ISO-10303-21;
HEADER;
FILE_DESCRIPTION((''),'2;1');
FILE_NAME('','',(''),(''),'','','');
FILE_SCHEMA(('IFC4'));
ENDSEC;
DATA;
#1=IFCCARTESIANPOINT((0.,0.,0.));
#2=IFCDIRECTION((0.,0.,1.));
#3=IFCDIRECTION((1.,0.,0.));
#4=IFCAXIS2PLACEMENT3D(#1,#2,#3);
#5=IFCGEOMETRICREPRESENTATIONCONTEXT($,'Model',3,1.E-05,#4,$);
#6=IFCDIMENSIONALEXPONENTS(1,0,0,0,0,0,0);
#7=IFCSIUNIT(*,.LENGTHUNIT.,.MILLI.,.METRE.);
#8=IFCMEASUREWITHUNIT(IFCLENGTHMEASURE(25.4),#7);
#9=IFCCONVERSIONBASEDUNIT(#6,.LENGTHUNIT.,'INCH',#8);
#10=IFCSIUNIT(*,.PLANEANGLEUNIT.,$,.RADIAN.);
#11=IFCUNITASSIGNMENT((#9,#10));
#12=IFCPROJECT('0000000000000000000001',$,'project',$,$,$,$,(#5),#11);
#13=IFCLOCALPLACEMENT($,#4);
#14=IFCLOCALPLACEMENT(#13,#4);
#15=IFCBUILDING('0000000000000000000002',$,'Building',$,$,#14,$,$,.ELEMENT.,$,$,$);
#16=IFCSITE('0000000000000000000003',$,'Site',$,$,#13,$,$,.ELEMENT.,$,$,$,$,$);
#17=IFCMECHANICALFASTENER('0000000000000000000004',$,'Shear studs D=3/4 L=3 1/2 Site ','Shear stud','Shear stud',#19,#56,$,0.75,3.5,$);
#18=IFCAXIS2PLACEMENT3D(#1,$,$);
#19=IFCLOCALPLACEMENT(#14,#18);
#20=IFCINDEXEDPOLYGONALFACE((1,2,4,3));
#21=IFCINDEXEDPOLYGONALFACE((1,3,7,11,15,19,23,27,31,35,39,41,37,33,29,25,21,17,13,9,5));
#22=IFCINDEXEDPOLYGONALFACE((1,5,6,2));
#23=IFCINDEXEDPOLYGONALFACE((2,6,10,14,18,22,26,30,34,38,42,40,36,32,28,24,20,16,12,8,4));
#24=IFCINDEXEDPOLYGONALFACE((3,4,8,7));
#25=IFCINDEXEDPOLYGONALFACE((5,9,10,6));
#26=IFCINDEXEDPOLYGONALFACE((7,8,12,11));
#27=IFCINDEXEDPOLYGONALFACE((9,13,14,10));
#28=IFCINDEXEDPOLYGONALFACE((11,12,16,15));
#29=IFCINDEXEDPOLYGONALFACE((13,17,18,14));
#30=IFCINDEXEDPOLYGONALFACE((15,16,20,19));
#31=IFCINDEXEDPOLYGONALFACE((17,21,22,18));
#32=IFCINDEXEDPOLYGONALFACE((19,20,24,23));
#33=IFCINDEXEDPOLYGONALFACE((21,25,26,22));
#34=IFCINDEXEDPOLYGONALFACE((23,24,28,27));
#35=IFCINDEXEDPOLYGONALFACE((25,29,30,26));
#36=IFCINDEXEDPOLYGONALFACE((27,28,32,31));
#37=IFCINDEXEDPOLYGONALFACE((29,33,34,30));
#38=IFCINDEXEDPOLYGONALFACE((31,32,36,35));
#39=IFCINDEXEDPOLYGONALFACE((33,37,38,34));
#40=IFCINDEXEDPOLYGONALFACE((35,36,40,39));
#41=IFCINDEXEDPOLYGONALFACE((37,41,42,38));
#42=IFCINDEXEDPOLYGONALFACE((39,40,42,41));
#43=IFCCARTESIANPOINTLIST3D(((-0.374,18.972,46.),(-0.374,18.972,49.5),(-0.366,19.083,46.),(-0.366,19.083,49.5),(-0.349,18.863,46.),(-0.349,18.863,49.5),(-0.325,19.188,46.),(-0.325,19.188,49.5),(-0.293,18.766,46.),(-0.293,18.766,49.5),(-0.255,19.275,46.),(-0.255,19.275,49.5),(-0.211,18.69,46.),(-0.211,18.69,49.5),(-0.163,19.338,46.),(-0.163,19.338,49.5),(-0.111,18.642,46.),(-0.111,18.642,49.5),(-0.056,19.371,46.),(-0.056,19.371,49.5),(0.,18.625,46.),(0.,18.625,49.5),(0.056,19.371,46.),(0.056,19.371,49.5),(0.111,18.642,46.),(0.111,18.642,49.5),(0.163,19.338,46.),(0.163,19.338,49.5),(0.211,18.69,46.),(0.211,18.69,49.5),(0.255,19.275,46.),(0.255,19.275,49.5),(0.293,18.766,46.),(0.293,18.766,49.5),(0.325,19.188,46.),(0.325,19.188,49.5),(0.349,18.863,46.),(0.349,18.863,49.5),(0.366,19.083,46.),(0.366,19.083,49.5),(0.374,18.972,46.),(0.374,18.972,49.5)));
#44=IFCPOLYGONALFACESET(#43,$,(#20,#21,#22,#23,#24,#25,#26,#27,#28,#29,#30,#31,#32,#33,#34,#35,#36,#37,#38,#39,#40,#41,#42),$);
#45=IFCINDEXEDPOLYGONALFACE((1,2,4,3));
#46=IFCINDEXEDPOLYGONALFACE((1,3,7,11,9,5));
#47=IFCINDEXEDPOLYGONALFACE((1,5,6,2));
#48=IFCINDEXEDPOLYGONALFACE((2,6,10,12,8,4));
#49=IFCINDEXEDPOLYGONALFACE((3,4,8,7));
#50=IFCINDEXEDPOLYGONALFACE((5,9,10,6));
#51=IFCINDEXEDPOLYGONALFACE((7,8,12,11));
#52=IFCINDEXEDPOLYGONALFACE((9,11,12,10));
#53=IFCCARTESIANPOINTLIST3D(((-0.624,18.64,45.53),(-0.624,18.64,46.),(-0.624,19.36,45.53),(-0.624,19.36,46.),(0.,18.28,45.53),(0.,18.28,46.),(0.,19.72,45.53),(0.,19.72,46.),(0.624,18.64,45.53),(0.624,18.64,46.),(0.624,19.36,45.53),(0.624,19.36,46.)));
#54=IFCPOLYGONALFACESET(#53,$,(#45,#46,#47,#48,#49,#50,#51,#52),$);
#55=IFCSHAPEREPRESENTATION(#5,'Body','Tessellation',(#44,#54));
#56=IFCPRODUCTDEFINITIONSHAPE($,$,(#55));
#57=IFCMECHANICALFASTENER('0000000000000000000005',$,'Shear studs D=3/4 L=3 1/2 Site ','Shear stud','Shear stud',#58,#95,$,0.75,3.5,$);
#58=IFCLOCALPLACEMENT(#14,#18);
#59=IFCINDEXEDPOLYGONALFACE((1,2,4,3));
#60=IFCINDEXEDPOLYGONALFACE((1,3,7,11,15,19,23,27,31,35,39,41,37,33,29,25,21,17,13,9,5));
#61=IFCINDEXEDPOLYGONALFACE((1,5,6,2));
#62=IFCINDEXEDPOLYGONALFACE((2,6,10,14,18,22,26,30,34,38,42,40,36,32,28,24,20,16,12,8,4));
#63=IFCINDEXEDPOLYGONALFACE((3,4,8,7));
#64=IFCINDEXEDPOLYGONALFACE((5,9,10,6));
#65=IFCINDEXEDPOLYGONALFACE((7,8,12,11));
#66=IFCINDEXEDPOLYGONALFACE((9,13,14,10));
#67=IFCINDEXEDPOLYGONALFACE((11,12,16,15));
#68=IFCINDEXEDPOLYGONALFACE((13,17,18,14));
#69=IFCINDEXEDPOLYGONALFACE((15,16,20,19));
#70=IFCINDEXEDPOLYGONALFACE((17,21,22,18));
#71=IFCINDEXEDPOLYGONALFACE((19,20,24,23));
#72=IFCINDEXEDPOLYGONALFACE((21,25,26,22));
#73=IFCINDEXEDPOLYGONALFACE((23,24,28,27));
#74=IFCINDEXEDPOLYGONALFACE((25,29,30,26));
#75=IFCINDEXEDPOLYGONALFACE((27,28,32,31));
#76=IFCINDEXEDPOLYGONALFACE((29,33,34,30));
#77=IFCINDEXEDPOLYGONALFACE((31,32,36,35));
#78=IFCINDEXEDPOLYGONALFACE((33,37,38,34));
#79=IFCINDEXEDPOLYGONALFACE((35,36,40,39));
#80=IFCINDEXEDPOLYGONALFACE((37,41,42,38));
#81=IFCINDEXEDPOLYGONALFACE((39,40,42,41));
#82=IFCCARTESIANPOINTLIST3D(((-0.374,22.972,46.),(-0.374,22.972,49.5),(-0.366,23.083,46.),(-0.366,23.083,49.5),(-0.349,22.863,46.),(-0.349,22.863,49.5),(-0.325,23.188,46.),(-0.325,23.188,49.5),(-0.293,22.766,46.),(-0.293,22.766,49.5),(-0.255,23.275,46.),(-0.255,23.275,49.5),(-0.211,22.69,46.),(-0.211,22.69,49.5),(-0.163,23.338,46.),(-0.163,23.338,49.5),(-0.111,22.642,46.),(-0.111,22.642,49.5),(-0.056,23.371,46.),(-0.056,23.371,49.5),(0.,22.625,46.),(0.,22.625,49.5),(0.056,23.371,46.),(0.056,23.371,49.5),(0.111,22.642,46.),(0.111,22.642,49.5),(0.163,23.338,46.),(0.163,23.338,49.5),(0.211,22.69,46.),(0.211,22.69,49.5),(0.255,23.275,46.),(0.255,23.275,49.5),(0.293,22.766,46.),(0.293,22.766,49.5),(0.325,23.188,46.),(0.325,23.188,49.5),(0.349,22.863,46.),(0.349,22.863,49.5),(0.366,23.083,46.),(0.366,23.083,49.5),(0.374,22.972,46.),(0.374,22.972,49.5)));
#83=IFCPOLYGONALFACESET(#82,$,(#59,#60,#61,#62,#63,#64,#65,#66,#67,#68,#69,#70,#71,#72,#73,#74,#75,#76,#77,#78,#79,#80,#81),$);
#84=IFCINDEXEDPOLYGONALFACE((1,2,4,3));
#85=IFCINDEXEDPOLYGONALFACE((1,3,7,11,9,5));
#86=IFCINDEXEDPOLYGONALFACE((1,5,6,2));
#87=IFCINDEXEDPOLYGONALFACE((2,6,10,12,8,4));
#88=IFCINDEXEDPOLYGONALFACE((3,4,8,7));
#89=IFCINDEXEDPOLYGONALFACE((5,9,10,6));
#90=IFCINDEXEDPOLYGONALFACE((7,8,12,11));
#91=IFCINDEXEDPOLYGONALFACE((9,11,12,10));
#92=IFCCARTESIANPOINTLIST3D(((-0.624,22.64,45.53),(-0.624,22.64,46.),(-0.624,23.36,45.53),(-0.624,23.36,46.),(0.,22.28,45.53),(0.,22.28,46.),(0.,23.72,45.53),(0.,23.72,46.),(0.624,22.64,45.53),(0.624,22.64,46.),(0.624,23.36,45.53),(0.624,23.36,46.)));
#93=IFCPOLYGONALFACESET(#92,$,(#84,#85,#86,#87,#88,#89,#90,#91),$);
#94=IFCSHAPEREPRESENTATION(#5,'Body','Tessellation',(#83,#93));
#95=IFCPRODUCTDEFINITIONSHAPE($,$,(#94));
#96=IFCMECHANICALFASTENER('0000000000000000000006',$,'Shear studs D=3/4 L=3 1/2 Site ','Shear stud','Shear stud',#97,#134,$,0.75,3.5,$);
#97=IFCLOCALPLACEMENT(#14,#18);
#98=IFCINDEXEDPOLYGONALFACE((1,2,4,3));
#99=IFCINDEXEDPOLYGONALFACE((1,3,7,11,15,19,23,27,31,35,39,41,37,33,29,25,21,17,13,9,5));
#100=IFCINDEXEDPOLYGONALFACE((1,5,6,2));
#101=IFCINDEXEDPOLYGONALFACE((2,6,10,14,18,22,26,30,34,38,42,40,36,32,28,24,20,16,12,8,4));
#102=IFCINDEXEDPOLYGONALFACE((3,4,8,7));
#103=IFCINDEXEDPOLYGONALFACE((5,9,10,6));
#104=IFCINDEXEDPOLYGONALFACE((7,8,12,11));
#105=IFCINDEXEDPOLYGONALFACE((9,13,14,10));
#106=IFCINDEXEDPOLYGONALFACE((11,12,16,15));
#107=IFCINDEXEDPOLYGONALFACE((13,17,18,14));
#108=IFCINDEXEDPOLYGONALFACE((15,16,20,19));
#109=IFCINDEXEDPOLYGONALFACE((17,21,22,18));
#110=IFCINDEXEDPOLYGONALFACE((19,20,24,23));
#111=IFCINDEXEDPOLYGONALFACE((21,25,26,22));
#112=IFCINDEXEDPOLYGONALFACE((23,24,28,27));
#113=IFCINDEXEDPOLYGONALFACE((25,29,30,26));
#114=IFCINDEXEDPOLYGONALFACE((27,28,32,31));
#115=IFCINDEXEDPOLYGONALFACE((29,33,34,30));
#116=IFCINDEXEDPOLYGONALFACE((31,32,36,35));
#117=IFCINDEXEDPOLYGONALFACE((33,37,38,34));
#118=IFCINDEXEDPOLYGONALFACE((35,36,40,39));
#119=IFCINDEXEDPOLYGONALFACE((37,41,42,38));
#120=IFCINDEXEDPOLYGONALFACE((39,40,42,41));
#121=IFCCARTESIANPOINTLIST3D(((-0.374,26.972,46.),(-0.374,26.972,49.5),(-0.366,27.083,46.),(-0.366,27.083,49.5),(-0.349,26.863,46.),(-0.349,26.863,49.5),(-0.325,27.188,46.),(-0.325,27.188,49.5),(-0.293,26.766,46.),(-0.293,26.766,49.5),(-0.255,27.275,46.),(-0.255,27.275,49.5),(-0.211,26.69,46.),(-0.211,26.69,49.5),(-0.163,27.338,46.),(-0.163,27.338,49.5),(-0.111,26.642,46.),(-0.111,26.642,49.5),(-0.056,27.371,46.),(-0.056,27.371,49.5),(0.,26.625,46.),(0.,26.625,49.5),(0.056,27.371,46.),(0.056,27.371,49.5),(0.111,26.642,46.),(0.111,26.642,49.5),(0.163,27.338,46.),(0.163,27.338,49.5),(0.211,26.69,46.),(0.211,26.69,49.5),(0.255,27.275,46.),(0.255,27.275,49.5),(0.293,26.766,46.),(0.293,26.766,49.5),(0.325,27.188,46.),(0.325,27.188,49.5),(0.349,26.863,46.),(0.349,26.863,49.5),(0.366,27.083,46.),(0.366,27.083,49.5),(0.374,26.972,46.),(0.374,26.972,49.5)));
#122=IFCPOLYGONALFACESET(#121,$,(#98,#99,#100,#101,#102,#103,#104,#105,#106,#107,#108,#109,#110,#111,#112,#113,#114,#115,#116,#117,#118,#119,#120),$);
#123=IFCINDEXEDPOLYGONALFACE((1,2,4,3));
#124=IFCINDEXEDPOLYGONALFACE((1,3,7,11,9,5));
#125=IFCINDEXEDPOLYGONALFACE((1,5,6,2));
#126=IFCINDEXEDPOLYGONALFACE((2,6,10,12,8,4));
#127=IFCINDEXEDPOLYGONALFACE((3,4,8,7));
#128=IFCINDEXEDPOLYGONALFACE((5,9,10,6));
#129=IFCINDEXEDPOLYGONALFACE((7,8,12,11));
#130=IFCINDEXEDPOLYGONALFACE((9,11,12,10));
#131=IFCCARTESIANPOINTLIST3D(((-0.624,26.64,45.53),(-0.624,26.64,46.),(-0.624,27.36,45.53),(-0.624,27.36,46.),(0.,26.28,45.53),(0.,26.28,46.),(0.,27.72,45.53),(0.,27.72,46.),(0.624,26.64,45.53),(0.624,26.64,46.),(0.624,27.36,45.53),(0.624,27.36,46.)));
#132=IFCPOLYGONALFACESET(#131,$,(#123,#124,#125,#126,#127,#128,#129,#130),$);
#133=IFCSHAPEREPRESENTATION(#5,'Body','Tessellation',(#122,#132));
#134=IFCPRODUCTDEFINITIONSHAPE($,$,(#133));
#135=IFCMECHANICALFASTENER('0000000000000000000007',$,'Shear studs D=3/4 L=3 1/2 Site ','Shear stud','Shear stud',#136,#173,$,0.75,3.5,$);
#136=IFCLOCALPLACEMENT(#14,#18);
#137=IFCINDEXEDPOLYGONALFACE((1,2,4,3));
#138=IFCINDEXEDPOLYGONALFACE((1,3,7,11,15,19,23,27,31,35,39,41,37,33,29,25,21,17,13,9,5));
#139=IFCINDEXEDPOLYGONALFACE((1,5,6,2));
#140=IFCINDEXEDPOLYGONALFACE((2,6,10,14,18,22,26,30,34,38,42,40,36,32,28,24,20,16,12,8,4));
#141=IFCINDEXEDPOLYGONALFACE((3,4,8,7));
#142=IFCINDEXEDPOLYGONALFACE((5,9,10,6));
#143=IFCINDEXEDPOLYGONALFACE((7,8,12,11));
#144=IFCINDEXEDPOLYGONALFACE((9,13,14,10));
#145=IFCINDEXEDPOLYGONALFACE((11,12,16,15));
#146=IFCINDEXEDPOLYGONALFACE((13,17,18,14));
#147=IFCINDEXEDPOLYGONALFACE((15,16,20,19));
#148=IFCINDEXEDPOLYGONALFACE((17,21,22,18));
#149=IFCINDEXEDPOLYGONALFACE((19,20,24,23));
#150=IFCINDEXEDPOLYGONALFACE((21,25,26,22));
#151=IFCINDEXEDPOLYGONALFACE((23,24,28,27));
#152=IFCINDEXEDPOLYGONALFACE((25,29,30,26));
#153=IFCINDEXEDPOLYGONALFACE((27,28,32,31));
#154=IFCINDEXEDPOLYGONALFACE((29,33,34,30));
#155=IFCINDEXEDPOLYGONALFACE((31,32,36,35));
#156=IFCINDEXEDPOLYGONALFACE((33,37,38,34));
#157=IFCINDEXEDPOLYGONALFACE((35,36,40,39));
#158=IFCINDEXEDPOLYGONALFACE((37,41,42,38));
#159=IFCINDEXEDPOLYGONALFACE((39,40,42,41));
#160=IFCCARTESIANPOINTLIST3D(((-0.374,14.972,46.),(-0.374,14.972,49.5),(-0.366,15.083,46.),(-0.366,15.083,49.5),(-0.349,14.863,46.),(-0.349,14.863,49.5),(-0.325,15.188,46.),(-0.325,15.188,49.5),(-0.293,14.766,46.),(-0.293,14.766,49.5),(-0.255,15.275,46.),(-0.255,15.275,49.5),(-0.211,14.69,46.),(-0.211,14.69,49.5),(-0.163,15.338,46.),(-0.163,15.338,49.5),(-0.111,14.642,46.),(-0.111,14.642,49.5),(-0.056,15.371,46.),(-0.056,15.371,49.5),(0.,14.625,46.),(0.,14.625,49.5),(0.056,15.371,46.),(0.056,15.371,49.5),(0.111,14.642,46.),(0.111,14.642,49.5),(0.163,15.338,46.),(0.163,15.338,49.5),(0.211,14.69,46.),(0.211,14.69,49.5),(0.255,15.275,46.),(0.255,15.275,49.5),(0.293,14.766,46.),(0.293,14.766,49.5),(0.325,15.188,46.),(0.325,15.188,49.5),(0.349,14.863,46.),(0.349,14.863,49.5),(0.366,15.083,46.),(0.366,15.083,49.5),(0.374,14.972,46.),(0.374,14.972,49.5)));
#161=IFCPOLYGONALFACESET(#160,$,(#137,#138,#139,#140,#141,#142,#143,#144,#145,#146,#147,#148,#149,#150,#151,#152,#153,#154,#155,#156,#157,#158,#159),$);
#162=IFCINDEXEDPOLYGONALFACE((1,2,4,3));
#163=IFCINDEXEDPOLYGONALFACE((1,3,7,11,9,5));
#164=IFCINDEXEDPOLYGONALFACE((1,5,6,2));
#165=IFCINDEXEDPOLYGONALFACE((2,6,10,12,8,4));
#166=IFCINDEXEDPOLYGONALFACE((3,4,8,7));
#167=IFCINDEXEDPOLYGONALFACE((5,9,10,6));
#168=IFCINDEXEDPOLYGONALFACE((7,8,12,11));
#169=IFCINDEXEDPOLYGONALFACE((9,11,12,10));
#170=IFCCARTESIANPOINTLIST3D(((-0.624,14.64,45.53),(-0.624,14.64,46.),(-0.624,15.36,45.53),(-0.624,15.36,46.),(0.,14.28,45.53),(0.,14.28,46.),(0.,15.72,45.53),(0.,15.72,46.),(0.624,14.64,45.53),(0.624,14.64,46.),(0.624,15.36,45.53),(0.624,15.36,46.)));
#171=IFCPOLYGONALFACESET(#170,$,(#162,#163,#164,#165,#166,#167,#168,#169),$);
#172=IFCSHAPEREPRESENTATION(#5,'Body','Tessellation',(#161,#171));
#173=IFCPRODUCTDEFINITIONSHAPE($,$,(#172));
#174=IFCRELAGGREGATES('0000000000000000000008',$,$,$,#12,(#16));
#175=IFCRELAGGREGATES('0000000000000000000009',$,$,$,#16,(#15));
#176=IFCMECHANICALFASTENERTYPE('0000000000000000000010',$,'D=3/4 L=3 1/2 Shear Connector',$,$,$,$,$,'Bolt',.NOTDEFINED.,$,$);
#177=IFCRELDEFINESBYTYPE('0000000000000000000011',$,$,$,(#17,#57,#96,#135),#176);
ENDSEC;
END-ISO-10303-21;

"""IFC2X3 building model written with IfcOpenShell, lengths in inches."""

from ifc_helpers import new_model, entity, si_unit, converted_unit, frame, origin_with_axes, origin_2d_with_axis, place, context, project, spatial, polyline, circle, outline, extrude, source, transform, mapped, type_object, type_shapes, element, save


model = new_model("IFC2X3")

# Units and contexts
model_context = context("Model", 3, precision=1e-05, world=origin_with_axes())
ifc_project = project(units=[converted_unit("LENGTHUNIT", "INCH", entity("IfcLengthMeasure", 25.4), si_unit("LENGTHUNIT", "METRE", prefix="MILLI"), dimensions=[1, 0, 0, 0, 0, 0, 0]), si_unit("PLANEANGLEUNIT", "RADIAN")], contexts=[model_context])

# Site, building
site_placement = place(None, origin_with_axes())
site = spatial("IfcSite", under=ifc_project, at=site_placement, Name="Site", CompositionType="ELEMENT")
building_placement = place(site_placement, origin_with_axes())
building = spatial("IfcBuilding", under=site, at=building_placement, Name="Building", CompositionType="ELEMENT")

# Mechanical fasteners
mechanical_fastener_type_1 = type_object("IfcMechanicalFastenerType", Name="D=3/4 L=3 1/2 Shear Connector", ElementType="Bolt")
shared_shape_1 = source(origin_with_axes(), model_context, "Body", "SweptSolid", [
    extrude(circle(Radius=0.375, at=origin_2d_with_axis()), frame((0.0, 0.0, 0.0), z_axis=(1.0, 0.0, 0.0), x_axis=(0.0, 1.0, 0.0)), (0.0, 0.0, 1.0), 3.5),
    extrude(outline(polyline([(-0.72, 0.0), (-0.36, 0.624), (0.36, 0.624), (0.72, 0.0), (0.36, -0.624), (-0.36, -0.624), (-0.72, 0.0)])), frame((0.0, 0.0, 0.0), z_axis=(1.0, 0.0, 0.0), x_axis=(0.0, 1.0, 0.0)), (0.0, 0.0, -1.0), 0.47),
])
type_shapes(mechanical_fastener_type_1, [shared_shape_1])
placement_1 = place(building_placement, frame((0.0, 0.0, 46.0), z_axis=(0.0, 0.0, 1.0), x_axis=(0.0, 1.0, 0.0)))
placement_2 = place(placement_1, frame((19.0, 0.0, 0.0), z_axis=(0.0, -1.0, 0.0), x_axis=(0.0, 0.0, 1.0)))
mechanical_fastener_1_placement = place(placement_2, origin_with_axes())
element("IfcMechanicalFastener", 1, at=mechanical_fastener_1_placement, type_object=mechanical_fastener_type_1, Name="Shear studs D=3/4 L=3 1/2 Site ", Description="Shear stud", ObjectType="Shear stud", NominalDiameter=0.75, NominalLength=3.5, context=model_context, shape_type="MappedRepresentation", body=[
    mapped(shared_shape_1, transform((0.0, 0.0, 0.0), scale=1.0)),
])
placement_3 = place(placement_1, frame((23.0, 0.0, 0.0), z_axis=(0.0, -1.0, 0.0), x_axis=(0.0, 0.0, 1.0)))
mechanical_fastener_2_placement = place(placement_3, origin_with_axes())
element("IfcMechanicalFastener", 2, at=mechanical_fastener_2_placement, type_object=mechanical_fastener_type_1, Name="Shear studs D=3/4 L=3 1/2 Site ", Description="Shear stud", ObjectType="Shear stud", NominalDiameter=0.75, NominalLength=3.5, context=model_context, shape_type="MappedRepresentation", body=[
    mapped(shared_shape_1, transform((0.0, 0.0, 0.0), scale=1.0)),
])
placement_4 = place(placement_1, frame((27.0, 0.0, 0.0), z_axis=(0.0, -1.0, 0.0), x_axis=(0.0, 0.0, 1.0)))
mechanical_fastener_3_placement = place(placement_4, origin_with_axes())
element("IfcMechanicalFastener", 3, at=mechanical_fastener_3_placement, type_object=mechanical_fastener_type_1, Name="Shear studs D=3/4 L=3 1/2 Site ", Description="Shear stud", ObjectType="Shear stud", NominalDiameter=0.75, NominalLength=3.5, context=model_context, shape_type="MappedRepresentation", body=[
    mapped(shared_shape_1, transform((0.0, 0.0, 0.0), scale=1.0)),
])
placement_5 = place(placement_1, frame((15.0, 0.0, 0.0), z_axis=(0.0, -1.0, 0.0), x_axis=(0.0, 0.0, 1.0)))
mechanical_fastener_4_placement = place(placement_5, origin_with_axes())
element("IfcMechanicalFastener", 4, at=mechanical_fastener_4_placement, type_object=mechanical_fastener_type_1, Name="Shear studs D=3/4 L=3 1/2 Site ", Description="Shear stud", ObjectType="Shear stud", NominalDiameter=0.75, NominalLength=3.5, context=model_context, shape_type="MappedRepresentation", body=[
    mapped(shared_shape_1, transform((0.0, 0.0, 0.0), scale=1.0)),
])

save(model, "model.ifc")
